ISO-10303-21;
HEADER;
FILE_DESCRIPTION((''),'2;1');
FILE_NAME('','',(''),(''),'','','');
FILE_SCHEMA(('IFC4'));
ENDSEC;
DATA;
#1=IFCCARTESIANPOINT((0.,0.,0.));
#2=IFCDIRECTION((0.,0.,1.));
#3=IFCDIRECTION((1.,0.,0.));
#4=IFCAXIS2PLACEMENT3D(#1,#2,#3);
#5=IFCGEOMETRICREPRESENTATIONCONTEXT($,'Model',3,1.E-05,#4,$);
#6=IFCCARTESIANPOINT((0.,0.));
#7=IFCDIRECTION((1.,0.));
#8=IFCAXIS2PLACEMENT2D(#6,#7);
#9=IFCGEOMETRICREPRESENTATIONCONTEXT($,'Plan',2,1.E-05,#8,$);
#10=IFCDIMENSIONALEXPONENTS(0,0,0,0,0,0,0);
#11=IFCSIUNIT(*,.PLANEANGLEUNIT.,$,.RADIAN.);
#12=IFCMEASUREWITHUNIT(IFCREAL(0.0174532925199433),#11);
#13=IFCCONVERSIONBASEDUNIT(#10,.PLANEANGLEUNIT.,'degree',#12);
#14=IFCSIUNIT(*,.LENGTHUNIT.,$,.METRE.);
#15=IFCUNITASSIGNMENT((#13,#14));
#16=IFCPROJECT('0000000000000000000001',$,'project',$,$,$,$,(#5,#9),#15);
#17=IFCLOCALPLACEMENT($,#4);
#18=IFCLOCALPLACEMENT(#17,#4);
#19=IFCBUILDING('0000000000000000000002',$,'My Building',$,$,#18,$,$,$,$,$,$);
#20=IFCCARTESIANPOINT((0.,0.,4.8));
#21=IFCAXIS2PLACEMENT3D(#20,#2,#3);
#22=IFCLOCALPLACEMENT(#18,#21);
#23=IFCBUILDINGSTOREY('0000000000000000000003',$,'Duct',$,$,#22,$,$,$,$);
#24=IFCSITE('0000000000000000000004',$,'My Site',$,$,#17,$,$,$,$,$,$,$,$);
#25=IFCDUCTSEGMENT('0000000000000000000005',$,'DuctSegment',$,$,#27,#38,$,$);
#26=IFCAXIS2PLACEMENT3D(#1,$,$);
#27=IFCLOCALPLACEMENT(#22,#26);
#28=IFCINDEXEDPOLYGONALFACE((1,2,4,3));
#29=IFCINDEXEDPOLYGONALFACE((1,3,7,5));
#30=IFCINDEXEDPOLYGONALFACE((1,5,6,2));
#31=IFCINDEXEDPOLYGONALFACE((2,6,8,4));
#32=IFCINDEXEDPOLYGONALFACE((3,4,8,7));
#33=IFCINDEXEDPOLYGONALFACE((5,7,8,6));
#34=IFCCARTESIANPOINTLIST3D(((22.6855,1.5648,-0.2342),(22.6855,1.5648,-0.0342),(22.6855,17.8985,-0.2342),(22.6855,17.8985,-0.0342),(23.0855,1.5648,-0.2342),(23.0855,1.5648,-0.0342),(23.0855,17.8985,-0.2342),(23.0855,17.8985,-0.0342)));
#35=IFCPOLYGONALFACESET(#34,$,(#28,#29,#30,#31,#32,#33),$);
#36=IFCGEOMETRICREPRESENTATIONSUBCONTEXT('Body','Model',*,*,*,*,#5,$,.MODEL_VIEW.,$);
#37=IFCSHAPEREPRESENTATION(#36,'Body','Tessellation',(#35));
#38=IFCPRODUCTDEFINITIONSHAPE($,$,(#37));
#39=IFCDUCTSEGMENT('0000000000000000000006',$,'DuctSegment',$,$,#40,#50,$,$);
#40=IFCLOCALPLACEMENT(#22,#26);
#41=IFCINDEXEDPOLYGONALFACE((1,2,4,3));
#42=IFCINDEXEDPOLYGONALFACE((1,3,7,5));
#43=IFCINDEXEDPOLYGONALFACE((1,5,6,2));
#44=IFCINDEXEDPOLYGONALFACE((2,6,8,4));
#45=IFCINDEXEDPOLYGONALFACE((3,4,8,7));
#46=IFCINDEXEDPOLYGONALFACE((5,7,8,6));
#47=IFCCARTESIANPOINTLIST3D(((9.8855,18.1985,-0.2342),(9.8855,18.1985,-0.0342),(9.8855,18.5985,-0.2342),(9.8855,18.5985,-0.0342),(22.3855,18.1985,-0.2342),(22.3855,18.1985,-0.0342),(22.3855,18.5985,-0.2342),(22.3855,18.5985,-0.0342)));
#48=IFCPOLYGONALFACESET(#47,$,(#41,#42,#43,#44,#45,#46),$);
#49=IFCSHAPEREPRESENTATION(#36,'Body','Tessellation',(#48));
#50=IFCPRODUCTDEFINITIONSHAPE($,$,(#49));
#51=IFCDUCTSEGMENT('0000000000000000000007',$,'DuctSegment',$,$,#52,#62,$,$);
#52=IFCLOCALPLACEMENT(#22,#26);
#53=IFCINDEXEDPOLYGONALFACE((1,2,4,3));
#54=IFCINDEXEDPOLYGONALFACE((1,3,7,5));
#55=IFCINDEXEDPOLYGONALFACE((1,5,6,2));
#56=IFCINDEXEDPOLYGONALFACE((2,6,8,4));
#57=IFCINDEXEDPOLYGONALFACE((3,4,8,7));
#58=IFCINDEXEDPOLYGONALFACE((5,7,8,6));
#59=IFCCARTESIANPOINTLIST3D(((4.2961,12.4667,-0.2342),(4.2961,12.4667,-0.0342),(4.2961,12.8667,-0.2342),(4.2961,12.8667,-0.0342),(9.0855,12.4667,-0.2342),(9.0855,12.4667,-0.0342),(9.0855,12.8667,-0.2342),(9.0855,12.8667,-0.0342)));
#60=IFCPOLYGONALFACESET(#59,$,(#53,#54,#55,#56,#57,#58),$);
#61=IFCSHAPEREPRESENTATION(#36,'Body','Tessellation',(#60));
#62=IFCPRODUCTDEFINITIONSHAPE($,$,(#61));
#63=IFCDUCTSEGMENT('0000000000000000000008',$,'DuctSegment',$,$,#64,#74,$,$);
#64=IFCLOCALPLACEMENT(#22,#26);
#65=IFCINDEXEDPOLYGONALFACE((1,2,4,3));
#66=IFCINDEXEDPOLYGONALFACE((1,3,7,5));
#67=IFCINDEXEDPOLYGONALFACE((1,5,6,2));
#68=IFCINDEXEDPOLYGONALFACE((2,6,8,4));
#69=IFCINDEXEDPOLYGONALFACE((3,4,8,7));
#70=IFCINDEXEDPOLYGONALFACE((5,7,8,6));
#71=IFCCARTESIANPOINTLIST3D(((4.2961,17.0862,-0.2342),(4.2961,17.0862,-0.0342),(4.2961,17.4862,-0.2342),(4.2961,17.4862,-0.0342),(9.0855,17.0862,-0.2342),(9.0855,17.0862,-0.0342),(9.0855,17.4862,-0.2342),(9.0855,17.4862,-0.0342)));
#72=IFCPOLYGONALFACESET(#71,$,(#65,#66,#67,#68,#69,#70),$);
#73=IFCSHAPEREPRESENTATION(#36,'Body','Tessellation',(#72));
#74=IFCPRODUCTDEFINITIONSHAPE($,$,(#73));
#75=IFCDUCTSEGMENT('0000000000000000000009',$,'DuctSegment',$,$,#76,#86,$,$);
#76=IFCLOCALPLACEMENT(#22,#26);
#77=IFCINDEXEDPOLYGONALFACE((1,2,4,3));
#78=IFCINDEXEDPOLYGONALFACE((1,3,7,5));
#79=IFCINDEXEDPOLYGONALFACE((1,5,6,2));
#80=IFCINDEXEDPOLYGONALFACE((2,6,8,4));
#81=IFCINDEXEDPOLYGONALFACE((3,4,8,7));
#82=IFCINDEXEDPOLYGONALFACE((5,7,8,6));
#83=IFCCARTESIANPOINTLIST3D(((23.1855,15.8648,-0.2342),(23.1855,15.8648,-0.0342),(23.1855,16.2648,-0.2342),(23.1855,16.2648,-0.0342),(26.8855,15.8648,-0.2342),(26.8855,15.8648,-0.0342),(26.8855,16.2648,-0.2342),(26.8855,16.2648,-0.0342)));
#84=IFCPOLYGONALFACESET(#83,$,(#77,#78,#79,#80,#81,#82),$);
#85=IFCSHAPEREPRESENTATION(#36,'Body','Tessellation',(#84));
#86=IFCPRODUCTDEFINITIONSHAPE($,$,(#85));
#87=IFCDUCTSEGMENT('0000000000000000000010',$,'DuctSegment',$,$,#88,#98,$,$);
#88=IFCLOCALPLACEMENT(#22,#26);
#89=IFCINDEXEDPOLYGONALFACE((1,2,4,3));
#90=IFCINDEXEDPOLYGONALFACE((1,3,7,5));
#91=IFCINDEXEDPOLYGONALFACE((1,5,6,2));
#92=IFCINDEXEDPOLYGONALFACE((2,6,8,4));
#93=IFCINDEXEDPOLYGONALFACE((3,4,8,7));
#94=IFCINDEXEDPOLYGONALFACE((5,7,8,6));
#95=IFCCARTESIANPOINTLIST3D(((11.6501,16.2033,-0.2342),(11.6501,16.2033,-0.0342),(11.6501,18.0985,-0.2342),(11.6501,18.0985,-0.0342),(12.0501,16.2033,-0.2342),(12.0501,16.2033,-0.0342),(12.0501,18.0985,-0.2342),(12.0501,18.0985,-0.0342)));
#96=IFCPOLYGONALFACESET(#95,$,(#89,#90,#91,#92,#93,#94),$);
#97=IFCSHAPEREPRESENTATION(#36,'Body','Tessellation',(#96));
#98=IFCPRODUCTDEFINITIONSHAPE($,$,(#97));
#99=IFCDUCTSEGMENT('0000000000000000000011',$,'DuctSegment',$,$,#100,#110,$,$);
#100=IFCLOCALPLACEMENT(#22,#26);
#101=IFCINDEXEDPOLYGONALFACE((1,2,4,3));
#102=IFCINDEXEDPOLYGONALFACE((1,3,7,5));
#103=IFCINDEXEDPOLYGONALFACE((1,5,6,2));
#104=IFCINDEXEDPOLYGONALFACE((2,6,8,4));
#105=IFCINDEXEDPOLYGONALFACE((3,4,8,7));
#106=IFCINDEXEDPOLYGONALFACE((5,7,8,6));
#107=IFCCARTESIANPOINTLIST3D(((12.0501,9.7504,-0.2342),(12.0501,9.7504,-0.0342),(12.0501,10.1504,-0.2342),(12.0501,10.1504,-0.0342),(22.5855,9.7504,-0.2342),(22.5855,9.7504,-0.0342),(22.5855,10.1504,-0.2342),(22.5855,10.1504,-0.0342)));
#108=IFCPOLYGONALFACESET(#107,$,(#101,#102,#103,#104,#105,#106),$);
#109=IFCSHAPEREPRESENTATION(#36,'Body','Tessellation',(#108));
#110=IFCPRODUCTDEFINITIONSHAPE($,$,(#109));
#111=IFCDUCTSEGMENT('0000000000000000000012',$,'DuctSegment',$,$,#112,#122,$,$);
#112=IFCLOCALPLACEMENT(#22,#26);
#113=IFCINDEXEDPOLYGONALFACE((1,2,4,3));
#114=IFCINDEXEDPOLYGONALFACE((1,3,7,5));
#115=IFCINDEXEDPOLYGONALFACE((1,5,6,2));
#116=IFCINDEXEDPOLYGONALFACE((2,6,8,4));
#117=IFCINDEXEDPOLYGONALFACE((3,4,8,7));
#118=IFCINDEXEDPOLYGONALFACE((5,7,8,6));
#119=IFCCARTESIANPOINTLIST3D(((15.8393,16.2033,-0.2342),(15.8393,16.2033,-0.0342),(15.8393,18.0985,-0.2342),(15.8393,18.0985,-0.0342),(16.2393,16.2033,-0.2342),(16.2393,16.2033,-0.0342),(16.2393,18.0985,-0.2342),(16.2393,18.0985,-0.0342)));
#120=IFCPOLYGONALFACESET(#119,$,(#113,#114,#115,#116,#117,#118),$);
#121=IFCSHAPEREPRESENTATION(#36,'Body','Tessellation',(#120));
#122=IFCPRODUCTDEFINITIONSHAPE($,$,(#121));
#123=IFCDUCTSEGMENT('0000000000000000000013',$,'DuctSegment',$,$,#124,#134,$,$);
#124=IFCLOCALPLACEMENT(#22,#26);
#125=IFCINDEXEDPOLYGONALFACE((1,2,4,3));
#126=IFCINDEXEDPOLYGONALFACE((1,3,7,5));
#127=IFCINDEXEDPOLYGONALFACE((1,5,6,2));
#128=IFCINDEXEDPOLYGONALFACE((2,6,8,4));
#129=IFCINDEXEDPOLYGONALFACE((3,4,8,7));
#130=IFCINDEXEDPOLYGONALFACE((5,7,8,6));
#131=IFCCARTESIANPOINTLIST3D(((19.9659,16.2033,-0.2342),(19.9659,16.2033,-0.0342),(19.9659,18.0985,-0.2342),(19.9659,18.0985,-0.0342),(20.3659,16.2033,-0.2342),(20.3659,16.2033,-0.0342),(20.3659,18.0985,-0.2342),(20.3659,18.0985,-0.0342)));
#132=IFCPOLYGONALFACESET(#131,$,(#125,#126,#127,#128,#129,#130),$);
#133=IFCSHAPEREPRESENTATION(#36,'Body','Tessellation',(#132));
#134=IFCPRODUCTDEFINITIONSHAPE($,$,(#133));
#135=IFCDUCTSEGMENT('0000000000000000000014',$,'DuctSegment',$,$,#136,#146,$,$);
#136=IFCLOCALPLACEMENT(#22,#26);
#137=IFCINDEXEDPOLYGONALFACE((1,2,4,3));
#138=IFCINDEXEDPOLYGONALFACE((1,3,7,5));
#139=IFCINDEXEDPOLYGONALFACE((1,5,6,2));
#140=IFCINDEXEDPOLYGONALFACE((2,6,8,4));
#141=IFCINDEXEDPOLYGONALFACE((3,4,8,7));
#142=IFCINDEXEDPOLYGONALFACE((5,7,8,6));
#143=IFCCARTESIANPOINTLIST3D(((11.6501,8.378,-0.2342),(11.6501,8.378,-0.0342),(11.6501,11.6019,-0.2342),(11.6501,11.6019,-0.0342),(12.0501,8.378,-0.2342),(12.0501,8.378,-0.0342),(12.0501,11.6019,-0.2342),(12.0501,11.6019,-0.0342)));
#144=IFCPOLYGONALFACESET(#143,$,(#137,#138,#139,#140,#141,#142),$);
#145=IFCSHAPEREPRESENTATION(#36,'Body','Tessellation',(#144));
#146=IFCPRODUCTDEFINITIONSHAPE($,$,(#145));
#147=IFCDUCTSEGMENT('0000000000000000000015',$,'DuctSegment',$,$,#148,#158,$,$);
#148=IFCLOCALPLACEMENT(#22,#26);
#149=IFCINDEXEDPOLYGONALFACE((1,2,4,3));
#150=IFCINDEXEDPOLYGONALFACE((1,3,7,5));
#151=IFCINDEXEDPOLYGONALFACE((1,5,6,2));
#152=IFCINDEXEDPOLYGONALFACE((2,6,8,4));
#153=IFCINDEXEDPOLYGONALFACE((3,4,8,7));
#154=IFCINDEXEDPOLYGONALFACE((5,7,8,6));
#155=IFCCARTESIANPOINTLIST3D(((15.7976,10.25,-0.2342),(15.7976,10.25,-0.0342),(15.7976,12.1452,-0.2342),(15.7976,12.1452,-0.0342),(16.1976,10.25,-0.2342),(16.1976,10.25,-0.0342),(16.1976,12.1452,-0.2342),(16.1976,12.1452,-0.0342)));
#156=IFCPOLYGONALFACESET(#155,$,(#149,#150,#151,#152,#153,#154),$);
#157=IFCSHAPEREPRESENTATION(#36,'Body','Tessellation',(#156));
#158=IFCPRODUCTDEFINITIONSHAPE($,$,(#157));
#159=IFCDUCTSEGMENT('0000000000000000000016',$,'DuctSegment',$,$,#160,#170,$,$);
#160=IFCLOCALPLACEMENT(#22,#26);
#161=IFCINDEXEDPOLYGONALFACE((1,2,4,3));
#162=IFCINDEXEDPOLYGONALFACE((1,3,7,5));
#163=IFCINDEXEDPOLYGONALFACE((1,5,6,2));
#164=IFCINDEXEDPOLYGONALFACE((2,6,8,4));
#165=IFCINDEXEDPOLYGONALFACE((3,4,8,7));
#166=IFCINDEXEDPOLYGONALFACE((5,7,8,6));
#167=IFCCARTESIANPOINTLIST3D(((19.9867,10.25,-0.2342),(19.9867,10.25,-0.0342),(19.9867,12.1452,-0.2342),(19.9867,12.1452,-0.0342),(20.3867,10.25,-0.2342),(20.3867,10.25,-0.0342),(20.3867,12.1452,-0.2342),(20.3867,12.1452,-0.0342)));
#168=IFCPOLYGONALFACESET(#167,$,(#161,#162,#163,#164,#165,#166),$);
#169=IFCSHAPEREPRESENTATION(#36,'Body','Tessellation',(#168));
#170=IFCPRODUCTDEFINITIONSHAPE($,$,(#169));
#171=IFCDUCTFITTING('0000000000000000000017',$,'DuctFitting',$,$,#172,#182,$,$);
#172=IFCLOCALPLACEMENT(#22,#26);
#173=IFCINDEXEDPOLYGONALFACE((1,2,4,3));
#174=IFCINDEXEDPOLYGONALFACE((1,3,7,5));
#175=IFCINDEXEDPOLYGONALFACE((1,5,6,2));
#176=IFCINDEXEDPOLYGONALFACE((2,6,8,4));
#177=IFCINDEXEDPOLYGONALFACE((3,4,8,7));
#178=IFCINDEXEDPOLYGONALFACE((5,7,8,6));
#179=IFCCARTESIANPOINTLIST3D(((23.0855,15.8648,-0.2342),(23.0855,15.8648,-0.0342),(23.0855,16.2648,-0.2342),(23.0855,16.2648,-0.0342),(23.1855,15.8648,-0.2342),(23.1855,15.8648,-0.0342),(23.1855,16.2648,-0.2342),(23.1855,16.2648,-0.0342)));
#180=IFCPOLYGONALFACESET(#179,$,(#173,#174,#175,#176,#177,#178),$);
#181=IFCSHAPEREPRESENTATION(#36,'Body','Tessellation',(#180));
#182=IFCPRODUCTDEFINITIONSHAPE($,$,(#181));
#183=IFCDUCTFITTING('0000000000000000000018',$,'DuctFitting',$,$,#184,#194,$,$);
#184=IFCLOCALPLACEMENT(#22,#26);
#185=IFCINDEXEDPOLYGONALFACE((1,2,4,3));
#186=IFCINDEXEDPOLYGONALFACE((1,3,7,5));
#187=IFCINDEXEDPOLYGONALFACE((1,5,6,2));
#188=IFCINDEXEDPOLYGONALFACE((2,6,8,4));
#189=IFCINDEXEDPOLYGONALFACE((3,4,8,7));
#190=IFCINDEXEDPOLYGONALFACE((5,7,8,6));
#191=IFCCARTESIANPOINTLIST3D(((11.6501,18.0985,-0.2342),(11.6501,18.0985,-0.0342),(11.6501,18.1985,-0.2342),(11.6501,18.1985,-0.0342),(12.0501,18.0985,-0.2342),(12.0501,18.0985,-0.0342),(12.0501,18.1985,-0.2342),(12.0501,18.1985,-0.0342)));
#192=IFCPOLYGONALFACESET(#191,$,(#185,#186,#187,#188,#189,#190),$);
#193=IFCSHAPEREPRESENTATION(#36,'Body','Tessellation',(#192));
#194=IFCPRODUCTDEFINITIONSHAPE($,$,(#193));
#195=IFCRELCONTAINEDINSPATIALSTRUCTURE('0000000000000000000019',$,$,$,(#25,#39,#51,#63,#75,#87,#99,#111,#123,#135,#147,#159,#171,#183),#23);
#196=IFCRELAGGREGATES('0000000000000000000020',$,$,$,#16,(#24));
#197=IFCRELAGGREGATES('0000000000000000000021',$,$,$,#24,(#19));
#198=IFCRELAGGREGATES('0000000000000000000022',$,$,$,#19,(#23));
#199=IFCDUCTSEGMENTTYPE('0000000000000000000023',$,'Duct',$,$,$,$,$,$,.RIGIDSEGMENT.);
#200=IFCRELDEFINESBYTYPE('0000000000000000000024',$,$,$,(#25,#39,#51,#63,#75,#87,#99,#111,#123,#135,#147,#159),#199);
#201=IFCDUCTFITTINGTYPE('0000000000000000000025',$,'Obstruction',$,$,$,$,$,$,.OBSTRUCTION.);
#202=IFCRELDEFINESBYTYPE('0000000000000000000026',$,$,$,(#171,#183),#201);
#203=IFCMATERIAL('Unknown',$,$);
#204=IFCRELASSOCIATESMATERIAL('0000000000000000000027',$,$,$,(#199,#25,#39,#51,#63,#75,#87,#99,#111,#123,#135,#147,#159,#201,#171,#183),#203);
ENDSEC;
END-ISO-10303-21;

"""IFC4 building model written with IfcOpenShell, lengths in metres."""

from ifc_helpers import new_model, entity, si_unit, converted_unit, frame, origin_with_axes, origin_2d_with_axis, place, context, subcontext, project, spatial, rectangle, extrude, material, material_profile, profile_set, profile_usage, type_object, element, save


model = new_model("IFC4")

# Units and contexts
model_context = context("Model", 3, precision=1e-05, world=origin_with_axes())
plan_context = context("Plan", 2, precision=1e-05, world=origin_2d_with_axis())
body_context = subcontext(model_context, "Body", "Model", "MODEL_VIEW")
ifc_project = project(units=[converted_unit("PLANEANGLEUNIT", "degree", entity("IfcReal", 0.0174532925199433), si_unit("PLANEANGLEUNIT", "RADIAN"), dimensions=[0, 0, 0, 0, 0, 0, 0]), si_unit("LENGTHUNIT", "METRE")], contexts=[model_context, plan_context])

# Site, building, storey
site_placement = place(None, origin_with_axes())
site = spatial("IfcSite", under=ifc_project, at=site_placement, Name="My Site")
building_placement = place(site_placement, origin_with_axes())
building = spatial("IfcBuilding", under=site, at=building_placement, Name="My Building")
storey_placement = place(building_placement, frame((0.0, 0.0, 4.8), z_axis=(0.0, 0.0, 1.0), x_axis=(1.0, 0.0, 0.0)))
storey = spatial("IfcBuildingStorey", under=building, at=storey_placement, Name="Duct")

# Duct segments
ifc_material = material(Name="Unknown")
ifc_material_profile_1 = material_profile(ifc_material, rectangle(XDim=0.4, YDim=0.2))
ifc_profile_set_1 = profile_set([ifc_material_profile_1])
ifc_profile_usage_1 = profile_usage(ifc_profile_set_1, cardinal=5)
duct_segment_type = type_object("IfcDuctSegmentType", Name="Duct", PredefinedType="RIGIDSEGMENT", material=ifc_profile_set_1)
duct_segment_1_placement = place(storey_placement, frame((22.8855, 17.8985, -0.1342), z_axis=(0.0, -1.0, 0.0), x_axis=(1.0, 0.0, 0.0)))
element("IfcDuctSegment", 1, at=duct_segment_1_placement, inside=storey, type_object=duct_segment_type, material=ifc_profile_usage_1, Name="DuctSegment", context=body_context, shape_type="SweptSolid", body=[
    extrude(rectangle(XDim=0.4, YDim=0.2), origin_with_axes(), (0.0, 0.0, 1.0), 16.3337),
])
ifc_profile_usage_2 = profile_usage(ifc_profile_set_1, cardinal=5)
duct_segment_2_placement = place(storey_placement, frame((9.8855, 18.3985, -0.1342), z_axis=(1.0, 0.0, 0.0), x_axis=(0.0, 1.0, 0.0)))
element("IfcDuctSegment", 2, at=duct_segment_2_placement, inside=storey, type_object=duct_segment_type, material=ifc_profile_usage_2, Name="DuctSegment", context=body_context, shape_type="SweptSolid", body=[
    extrude(rectangle(XDim=0.4, YDim=0.2), origin_with_axes(), (0.0, 0.0, 1.0), 12.5),
])
ifc_profile_usage_3 = profile_usage(ifc_profile_set_1, cardinal=5)
duct_segment_3_placement = place(storey_placement, frame((9.0855, 12.6667, -0.1342), z_axis=(-1.0, 0.0, 0.0), x_axis=(0.0, -1.0, 0.0)))
element("IfcDuctSegment", 3, at=duct_segment_3_placement, inside=storey, type_object=duct_segment_type, material=ifc_profile_usage_3, Name="DuctSegment", context=body_context, shape_type="SweptSolid", body=[
    extrude(rectangle(XDim=0.4, YDim=0.2), origin_with_axes(), (0.0, 0.0, 1.0), 4.7893),
])
ifc_profile_usage_4 = profile_usage(ifc_profile_set_1, cardinal=5)
duct_segment_4_placement = place(storey_placement, frame((9.0855, 17.2862, -0.1342), z_axis=(-1.0, 0.0, 0.0), x_axis=(0.0, -1.0, 0.0)))
element("IfcDuctSegment", 4, at=duct_segment_4_placement, inside=storey, type_object=duct_segment_type, material=ifc_profile_usage_4, Name="DuctSegment", context=body_context, shape_type="SweptSolid", body=[
    extrude(rectangle(XDim=0.4, YDim=0.2), origin_with_axes(), (0.0, 0.0, 1.0), 4.7893),
])
ifc_profile_usage_5 = profile_usage(ifc_profile_set_1, cardinal=5)
duct_segment_5_placement = place(storey_placement, frame((23.1855, 16.0648, -0.1342), z_axis=(1.0, 0.0, 0.0), x_axis=(0.0, 1.0, 0.0)))
element("IfcDuctSegment", 5, at=duct_segment_5_placement, inside=storey, type_object=duct_segment_type, material=ifc_profile_usage_5, Name="DuctSegment", context=body_context, shape_type="SweptSolid", body=[
    extrude(rectangle(XDim=0.4, YDim=0.2), origin_with_axes(), (0.0, 0.0, 1.0), 3.7),
])
ifc_profile_usage_6 = profile_usage(ifc_profile_set_1, cardinal=5)
duct_segment_6_placement = place(storey_placement, frame((11.8501, 16.2033, -0.1342), z_axis=(0.0, 1.0, 0.0), x_axis=(-1.0, 0.0, 0.0)))
element("IfcDuctSegment", 6, at=duct_segment_6_placement, inside=storey, type_object=duct_segment_type, material=ifc_profile_usage_6, Name="DuctSegment", context=body_context, shape_type="SweptSolid", body=[
    extrude(rectangle(XDim=0.4, YDim=0.2), origin_with_axes(), (0.0, 0.0, 1.0), 1.8952),
])
ifc_profile_usage_7 = profile_usage(ifc_profile_set_1, cardinal=5)
duct_segment_7_placement = place(storey_placement, frame((22.5855, 9.9504, -0.1342), z_axis=(-1.0, 0.0, 0.0), x_axis=(0.0, -1.0, 0.0)))
element("IfcDuctSegment", 7, at=duct_segment_7_placement, inside=storey, type_object=duct_segment_type, material=ifc_profile_usage_7, Name="DuctSegment", context=body_context, shape_type="SweptSolid", body=[
    extrude(rectangle(XDim=0.4, YDim=0.2), origin_with_axes(), (0.0, 0.0, 1.0), 10.5353),
])
ifc_profile_usage_8 = profile_usage(ifc_profile_set_1, cardinal=5)
duct_segment_8_placement = place(storey_placement, frame((16.0393, 16.2033, -0.1342), z_axis=(0.0, 1.0, 0.0), x_axis=(-1.0, 0.0, 0.0)))
element("IfcDuctSegment", 8, at=duct_segment_8_placement, inside=storey, type_object=duct_segment_type, material=ifc_profile_usage_8, Name="DuctSegment", context=body_context, shape_type="SweptSolid", body=[
    extrude(rectangle(XDim=0.4, YDim=0.2), origin_with_axes(), (0.0, 0.0, 1.0), 1.8952),
])
ifc_profile_usage_9 = profile_usage(ifc_profile_set_1, cardinal=5)
duct_segment_9_placement = place(storey_placement, frame((20.1659, 16.2033, -0.1342), z_axis=(0.0, 1.0, 0.0), x_axis=(-1.0, 0.0, 0.0)))
element("IfcDuctSegment", 9, at=duct_segment_9_placement, inside=storey, type_object=duct_segment_type, material=ifc_profile_usage_9, Name="DuctSegment", context=body_context, shape_type="SweptSolid", body=[
    extrude(rectangle(XDim=0.4, YDim=0.2), origin_with_axes(), (0.0, 0.0, 1.0), 1.8952),
])
ifc_profile_usage_10 = profile_usage(ifc_profile_set_1, cardinal=5)
duct_segment_10_placement = place(storey_placement, frame((11.8501, 11.6019, -0.1342), z_axis=(0.0, -1.0, -0.000001), x_axis=(1.0, 0.0, 0.0)))
element("IfcDuctSegment", 10, at=duct_segment_10_placement, inside=storey, type_object=duct_segment_type, material=ifc_profile_usage_10, Name="DuctSegment", context=body_context, shape_type="SweptSolid", body=[
    extrude(rectangle(XDim=0.4, YDim=0.2), origin_with_axes(), (0.0, 0.0, 1.0), 3.2239),
])
ifc_profile_usage_11 = profile_usage(ifc_profile_set_1, cardinal=5)
duct_segment_11_placement = place(storey_placement, frame((15.9976, 12.1452, -0.1342), z_axis=(0.000001, -1.0, 0.0), x_axis=(1.0, 0.000001, 0.0)))
element("IfcDuctSegment", 11, at=duct_segment_11_placement, inside=storey, type_object=duct_segment_type, material=ifc_profile_usage_11, Name="DuctSegment", context=body_context, shape_type="SweptSolid", body=[
    extrude(rectangle(XDim=0.4, YDim=0.2), origin_with_axes(), (0.0, 0.0, 1.0), 1.8952),
])
ifc_profile_usage_12 = profile_usage(ifc_profile_set_1, cardinal=5)
duct_segment_12_placement = place(storey_placement, frame((20.1867, 12.1452, -0.1342), z_axis=(0.000001, -1.0, 0.0), x_axis=(1.0, 0.000001, 0.0)))
element("IfcDuctSegment", 12, at=duct_segment_12_placement, inside=storey, type_object=duct_segment_type, material=ifc_profile_usage_12, Name="DuctSegment", context=body_context, shape_type="SweptSolid", body=[
    extrude(rectangle(XDim=0.4, YDim=0.2), origin_with_axes(), (0.0, 0.0, 1.0), 1.8952),
])

# Duct fittings
ifc_material_profile_2 = material_profile(ifc_material, rectangle(XDim=0.4, YDim=0.2))
ifc_profile_set_2 = profile_set([ifc_material_profile_2])
ifc_profile_usage_13 = profile_usage(ifc_profile_set_2, cardinal=5)
duct_fitting_type_1 = type_object("IfcDuctFittingType", Name="Obstruction", PredefinedType="OBSTRUCTION", material=ifc_profile_set_2)
duct_fitting_1_placement = place(storey_placement, frame((23.0855, 16.0648, -0.1342), z_axis=(1.0, 0.0, 0.0), x_axis=(0.0, 1.0, 0.0)))
element("IfcDuctFitting", 13, at=duct_fitting_1_placement, inside=storey, type_object=duct_fitting_type_1, material=ifc_profile_usage_13, Name="DuctFitting", context=body_context, shape_type="SweptSolid", body=[
    extrude(rectangle(XDim=0.4, YDim=0.2), origin_with_axes(), (0.0, 0.0, 1.0), 0.1),
])
ifc_profile_usage_14 = profile_usage(ifc_profile_set_2, cardinal=5)
duct_fitting_2_placement = place(storey_placement, frame((11.8501, 18.0985, -0.1342), z_axis=(0.0, 1.0, 0.0), x_axis=(-1.0, 0.0, 0.0)))
element("IfcDuctFitting", 14, at=duct_fitting_2_placement, inside=storey, type_object=duct_fitting_type_1, material=ifc_profile_usage_14, Name="DuctFitting", context=body_context, shape_type="SweptSolid", body=[
    extrude(rectangle(XDim=0.4, YDim=0.2), origin_with_axes(), (0.0, 0.0, 1.0), 0.1),
])

save(model, "model.ifc")
